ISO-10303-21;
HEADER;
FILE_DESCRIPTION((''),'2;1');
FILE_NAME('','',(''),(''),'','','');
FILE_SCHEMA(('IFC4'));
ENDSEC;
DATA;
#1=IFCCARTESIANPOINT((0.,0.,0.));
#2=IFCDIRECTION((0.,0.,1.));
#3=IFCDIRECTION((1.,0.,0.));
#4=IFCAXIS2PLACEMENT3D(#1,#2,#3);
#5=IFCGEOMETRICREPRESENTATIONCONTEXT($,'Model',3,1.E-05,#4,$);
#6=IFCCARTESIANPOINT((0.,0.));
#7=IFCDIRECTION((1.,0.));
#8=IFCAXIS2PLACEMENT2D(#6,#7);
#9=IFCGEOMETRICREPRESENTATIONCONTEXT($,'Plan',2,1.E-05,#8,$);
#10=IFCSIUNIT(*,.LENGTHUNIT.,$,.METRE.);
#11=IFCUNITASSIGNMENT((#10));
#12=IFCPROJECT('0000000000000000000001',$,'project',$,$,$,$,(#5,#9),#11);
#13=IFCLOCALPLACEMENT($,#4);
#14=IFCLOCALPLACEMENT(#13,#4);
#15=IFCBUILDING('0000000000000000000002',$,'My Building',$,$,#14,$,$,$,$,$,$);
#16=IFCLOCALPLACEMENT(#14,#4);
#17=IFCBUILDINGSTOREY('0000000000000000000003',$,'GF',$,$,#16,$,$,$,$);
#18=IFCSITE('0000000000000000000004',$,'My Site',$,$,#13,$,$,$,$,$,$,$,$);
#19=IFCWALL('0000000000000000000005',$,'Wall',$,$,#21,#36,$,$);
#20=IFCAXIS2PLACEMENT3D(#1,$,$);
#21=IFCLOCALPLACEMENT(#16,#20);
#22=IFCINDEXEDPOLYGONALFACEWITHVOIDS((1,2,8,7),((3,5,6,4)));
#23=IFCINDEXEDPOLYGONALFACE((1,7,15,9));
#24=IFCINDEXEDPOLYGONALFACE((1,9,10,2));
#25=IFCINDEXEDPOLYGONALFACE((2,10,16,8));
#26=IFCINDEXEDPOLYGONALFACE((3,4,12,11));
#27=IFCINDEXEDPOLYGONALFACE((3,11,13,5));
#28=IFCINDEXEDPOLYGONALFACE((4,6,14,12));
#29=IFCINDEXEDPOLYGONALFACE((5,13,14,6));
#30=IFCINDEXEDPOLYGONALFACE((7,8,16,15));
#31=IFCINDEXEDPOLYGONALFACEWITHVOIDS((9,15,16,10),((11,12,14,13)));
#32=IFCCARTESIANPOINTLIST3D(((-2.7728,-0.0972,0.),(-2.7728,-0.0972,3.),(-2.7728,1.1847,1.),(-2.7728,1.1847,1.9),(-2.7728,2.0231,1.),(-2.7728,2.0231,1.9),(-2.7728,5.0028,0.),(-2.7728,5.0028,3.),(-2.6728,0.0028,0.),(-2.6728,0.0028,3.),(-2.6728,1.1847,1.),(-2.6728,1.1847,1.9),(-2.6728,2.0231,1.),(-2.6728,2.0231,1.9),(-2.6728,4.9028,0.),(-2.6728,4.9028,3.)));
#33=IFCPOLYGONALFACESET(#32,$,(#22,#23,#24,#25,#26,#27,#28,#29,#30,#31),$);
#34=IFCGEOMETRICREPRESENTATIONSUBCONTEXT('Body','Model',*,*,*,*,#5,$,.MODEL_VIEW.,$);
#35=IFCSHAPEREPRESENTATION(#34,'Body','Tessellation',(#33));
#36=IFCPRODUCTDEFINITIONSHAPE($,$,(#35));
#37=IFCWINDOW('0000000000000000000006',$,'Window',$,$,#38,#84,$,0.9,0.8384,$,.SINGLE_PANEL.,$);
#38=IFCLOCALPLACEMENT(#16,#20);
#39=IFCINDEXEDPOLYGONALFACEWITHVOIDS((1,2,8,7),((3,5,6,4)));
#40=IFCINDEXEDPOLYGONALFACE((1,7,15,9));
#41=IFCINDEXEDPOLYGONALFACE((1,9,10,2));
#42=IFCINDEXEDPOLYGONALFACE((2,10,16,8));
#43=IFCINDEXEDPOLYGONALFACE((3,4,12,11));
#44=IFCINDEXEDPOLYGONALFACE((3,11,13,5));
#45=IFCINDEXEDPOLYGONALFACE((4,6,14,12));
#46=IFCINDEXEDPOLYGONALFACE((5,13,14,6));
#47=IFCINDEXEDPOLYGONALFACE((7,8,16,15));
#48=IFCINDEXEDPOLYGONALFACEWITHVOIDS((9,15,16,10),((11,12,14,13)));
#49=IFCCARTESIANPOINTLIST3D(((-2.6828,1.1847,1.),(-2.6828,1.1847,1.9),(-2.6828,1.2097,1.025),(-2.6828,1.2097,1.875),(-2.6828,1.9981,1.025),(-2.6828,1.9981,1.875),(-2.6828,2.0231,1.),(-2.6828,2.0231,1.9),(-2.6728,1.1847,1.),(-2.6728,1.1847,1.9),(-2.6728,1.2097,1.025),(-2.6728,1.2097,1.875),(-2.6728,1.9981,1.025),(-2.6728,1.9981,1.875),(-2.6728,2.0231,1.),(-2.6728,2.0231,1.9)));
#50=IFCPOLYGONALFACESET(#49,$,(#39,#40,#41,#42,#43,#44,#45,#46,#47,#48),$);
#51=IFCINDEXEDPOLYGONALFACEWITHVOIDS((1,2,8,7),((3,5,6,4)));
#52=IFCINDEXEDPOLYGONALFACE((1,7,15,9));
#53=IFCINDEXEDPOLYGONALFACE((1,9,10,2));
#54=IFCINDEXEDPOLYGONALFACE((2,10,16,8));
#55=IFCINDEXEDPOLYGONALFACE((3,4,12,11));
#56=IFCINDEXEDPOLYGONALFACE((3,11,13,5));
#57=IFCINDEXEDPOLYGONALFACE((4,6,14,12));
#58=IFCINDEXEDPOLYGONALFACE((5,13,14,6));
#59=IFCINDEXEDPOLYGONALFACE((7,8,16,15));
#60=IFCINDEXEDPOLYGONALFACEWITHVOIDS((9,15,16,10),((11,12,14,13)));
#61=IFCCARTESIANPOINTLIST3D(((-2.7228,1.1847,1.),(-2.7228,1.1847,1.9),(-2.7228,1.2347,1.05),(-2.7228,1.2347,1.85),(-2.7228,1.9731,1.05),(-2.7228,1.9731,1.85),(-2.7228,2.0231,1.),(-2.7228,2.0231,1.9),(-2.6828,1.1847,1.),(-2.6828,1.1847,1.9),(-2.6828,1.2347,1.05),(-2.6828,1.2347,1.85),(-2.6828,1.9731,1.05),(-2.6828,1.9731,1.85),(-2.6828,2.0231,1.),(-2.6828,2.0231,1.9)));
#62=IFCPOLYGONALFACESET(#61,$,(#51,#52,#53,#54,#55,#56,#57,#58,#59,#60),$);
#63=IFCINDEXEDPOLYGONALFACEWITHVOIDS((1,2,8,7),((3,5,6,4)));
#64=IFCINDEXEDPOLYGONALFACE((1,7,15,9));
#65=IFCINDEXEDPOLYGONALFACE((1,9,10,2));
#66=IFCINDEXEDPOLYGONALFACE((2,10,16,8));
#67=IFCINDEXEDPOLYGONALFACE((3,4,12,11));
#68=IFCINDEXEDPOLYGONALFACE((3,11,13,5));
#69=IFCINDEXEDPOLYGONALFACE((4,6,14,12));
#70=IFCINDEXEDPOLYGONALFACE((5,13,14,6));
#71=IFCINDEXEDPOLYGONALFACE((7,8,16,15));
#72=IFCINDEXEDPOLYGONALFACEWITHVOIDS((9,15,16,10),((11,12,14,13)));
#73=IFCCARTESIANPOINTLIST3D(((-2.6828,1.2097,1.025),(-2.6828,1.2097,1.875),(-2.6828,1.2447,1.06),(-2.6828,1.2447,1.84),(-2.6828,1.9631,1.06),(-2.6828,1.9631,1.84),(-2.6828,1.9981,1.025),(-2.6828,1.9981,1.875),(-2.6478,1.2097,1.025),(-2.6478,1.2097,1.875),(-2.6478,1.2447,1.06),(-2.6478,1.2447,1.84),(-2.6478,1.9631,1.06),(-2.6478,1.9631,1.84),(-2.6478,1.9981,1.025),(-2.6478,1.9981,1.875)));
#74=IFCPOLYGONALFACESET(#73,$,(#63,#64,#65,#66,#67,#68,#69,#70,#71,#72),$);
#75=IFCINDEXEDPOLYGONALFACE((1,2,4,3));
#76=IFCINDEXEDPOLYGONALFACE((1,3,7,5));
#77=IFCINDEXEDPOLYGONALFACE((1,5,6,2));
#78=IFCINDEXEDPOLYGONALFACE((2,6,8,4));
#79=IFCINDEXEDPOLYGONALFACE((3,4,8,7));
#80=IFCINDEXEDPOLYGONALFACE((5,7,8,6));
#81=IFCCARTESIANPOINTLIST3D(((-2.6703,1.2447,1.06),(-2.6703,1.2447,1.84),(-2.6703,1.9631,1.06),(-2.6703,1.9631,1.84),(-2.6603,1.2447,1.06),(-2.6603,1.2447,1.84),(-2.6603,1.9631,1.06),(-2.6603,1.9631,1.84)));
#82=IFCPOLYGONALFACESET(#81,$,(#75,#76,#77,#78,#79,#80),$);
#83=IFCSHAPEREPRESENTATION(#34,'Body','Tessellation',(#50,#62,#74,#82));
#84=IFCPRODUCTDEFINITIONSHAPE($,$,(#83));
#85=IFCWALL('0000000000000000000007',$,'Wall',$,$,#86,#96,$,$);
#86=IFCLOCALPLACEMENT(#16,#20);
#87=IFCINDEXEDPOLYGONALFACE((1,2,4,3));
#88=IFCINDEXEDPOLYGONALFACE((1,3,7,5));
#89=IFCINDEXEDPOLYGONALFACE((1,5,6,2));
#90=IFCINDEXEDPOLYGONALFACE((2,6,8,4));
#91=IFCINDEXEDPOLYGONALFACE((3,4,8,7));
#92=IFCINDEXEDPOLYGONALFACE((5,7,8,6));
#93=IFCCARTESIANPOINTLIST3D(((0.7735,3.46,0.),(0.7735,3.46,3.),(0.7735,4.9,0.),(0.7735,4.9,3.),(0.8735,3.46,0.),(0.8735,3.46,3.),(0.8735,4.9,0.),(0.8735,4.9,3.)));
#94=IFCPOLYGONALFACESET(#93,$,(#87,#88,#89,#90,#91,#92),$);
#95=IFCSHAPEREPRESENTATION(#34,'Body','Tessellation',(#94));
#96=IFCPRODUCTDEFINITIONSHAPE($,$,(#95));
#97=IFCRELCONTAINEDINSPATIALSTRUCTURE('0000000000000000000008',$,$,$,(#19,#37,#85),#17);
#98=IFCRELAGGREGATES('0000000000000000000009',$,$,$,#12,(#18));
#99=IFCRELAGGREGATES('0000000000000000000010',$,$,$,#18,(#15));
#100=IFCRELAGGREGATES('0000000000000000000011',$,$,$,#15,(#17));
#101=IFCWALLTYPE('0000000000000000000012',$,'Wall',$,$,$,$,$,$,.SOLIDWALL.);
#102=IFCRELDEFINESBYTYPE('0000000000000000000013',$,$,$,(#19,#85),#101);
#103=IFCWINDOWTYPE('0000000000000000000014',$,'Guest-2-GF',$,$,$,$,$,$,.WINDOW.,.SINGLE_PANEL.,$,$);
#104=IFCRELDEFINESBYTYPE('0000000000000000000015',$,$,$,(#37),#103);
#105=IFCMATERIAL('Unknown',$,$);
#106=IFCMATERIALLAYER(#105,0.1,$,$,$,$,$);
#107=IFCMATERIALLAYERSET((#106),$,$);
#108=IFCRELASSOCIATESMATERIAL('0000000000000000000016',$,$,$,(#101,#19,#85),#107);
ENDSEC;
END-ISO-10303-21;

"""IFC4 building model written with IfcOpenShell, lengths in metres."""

from ifc_helpers import new_model, entity, si_unit, frame, origin_with_axes, origin_2d_with_axis, place, context, subcontext, project, spatial, line, indexed_curve, outline, extrude, shape, source, transform, mapped, material, layer, layer_set, layer_usage, type_object, type_shapes, element, fill, save


model = new_model("IFC4")

# Units and contexts
model_context = context("Model", 3, precision=1e-05, world=origin_with_axes())
plan_context = context("Plan", 2, precision=1e-05, world=origin_2d_with_axis())
body_context_1 = subcontext(model_context, "Body", "Model", "MODEL_VIEW")
body_context_2 = subcontext(plan_context, "Body", "Plan", "PLAN_VIEW")
ifc_project = project(units=[si_unit("LENGTHUNIT", "METRE")], contexts=[model_context, plan_context])

# Site, building, storey
site_placement = place(None, origin_with_axes())
site = spatial("IfcSite", under=ifc_project, at=site_placement, Name="My Site")
building_placement = place(site_placement, origin_with_axes())
building = spatial("IfcBuilding", under=site, at=building_placement, Name="My Building")
storey_placement = place(building_placement, origin_with_axes())
storey = spatial("IfcBuildingStorey", under=building, at=storey_placement, Name="GF")

# Shared definitions
ifc_material_1 = material(Name="Unknown")

# Shared definitions
ifc_layer_1 = layer(ifc_material_1, 0.1)
ifc_layer_set_1 = layer_set([ifc_layer_1])
wall_type = type_object("IfcWallType", Name="Wall", PredefinedType="SOLIDWALL", material=ifc_layer_set_1)

# Wall, opening, window
ifc_layer_usage_1 = layer_usage(ifc_layer_set_1, "AXIS2", "POSITIVE", 0.0)
wall_1_placement = place(storey_placement, frame((-2.7728, 5.0028, 0.0), z_axis=(0.0, 0.0, 1.0), x_axis=(0.0, -1.0, 0.0)))
wall_1 = element("IfcWall", 1, at=wall_1_placement, inside=storey, type_object=wall_type, material=ifc_layer_usage_1, Name="Wall", context=body_context_1, shape_type="SweptSolid", body=[
    extrude(outline(indexed_curve([(0.0, 0.0), (0.1, 0.1), (5.0, 0.1), (5.1, 0.0)], segments=[line(1, 2, 3, 4, 1)])), origin_with_axes(), (0.0, 0.0, 1.0), 3.0),
])
shared_shape_1 = source(origin_with_axes(), body_context_1, "Body", "SweptSolid", [
    extrude(outline(indexed_curve([(0.0, 0.0), (0.8384, 0.0), (0.8384, 0.9), (0.0, 0.9)], segments=[line(1, 2, 3, 4, 1)])), frame((0.0, -0.6, 0.0), z_axis=(0.0, -1.0, 0.0), x_axis=(1.0, 0.0, 0.0)), (0.0, 0.0, -1.0), 1.2),
])
opening_1_placement = place(wall_1_placement, frame((2.9797, 0.0, 1.0), z_axis=(0.0, 0.0, 1.0), x_axis=(1.0, 0.0, 0.0)))
opening_1 = element("IfcOpeningElement", 2, at=opening_1_placement, cuts=wall_1, PredefinedType="OPENING", context=body_context_1, shape_type="MappedRepresentation", body=[
    mapped(shared_shape_1, transform((0.0, 0.0, 0.0), x_axis=(1.0, 0.0, 0.0), y_axis=(0.0, 1.0, 0.0), z_axis=(0.0, 0.0, 1.0), scale=1.0)),
])
window_type_1 = type_object("IfcWindowType", Name="Guest-2-GF", PartitioningType="SINGLE_PANEL", PredefinedType="WINDOW")
shared_shape_2 = source(origin_with_axes(), body_context_1, "Body", "SweptSolid", [
    extrude(outline(indexed_curve([(0.0, 0.0), (0.8384, 0.0), (0.8384, 0.9), (0.0, 0.9)], segments=[line(1, 2, 3, 4, 1)]), holes=[indexed_curve([(0.025, 0.025), (0.8134, 0.025), (0.8134, 0.875), (0.025, 0.875)], segments=[line(1, 2, 3, 4, 1)])]), frame((0.0, 0.09, 0.0), z_axis=(0.0, -1.0, 0.0), x_axis=(1.0, 0.0, 0.0)), (0.0, 0.0, -1.0), 0.01),
    extrude(outline(indexed_curve([(0.0, 0.0), (0.8384, 0.0), (0.8384, 0.9), (0.0, 0.9)], segments=[line(1, 2, 3, 4, 1)]), holes=[indexed_curve([(0.05, 0.05), (0.7884, 0.05), (0.7884, 0.85), (0.05, 0.85)], segments=[line(1, 2, 3, 4, 1)])]), frame((0.0, 0.05, 0.0), z_axis=(0.0, -1.0, 0.0), x_axis=(1.0, 0.0, 0.0)), (0.0, 0.0, -1.0), 0.04),
    extrude(outline(indexed_curve([(0.0, 0.0), (0.7884, 0.0), (0.7884, 0.85), (0.0, 0.85)], segments=[line(1, 2, 3, 4, 1)]), holes=[indexed_curve([(0.035, 0.035), (0.7534, 0.035), (0.7534, 0.815), (0.035, 0.815)], segments=[line(1, 2, 3, 4, 1)])]), frame((0.025, 0.09, 0.025), z_axis=(0.0, -1.0, 0.0), x_axis=(1.0, 0.0, 0.0)), (0.0, 0.0, -1.0), 0.035),
    extrude(outline(indexed_curve([(0.035, 0.035), (0.7534, 0.035), (0.7534, 0.815), (0.035, 0.815)], segments=[line(1, 2, 3, 4, 1)])), frame((0.025, 0.1025, 0.025), z_axis=(0.0, -1.0, 0.0), x_axis=(1.0, 0.0, 0.0)), (0.0, 0.0, -1.0), 0.01),
])
shared_shape_3 = source(origin_with_axes(), body_context_2, "Body", "Curve2D", [
    entity("IfcIndexedPolyCurve", entity("IfcCartesianPointList2D", [[0.05, 0.05], [0.7884, 0.05]])),
    entity("IfcIndexedPolyCurve", entity("IfcCartesianPointList2D", [[0.0, 0.1], [0.025, 0.1], [0.025, 0.09], [0.05, 0.09], [0.05, 0.05], [0.0, 0.05]]), [entity("IfcLineIndex", [1, 2, 3, 4, 5, 6, 1])]),
    entity("IfcIndexedPolyCurve", entity("IfcCartesianPointList2D", [[0.8384, 0.1], [0.8134, 0.1], [0.8134, 0.09], [0.7884, 0.09], [0.7884, 0.05], [0.8384, 0.05]]), [entity("IfcLineIndex", [1, 2, 3, 4, 5, 6, 1])]),
    entity("IfcIndexedPolyCurve", entity("IfcCartesianPointList2D", [[0.025, 0.09], [0.06, 0.09], [0.06, 0.125], [0.025, 0.125]]), [entity("IfcLineIndex", [1, 2, 3, 4, 1])]),
    entity("IfcIndexedPolyCurve", entity("IfcCartesianPointList2D", [[0.8134, 0.09], [0.7784, 0.09], [0.7784, 0.125], [0.8134, 0.125]]), [entity("IfcLineIndex", [1, 2, 3, 4, 1])]),
    entity("IfcIndexedPolyCurve", entity("IfcCartesianPointList2D", [[0.06, 0.09], [0.7784, 0.09]])),
    entity("IfcIndexedPolyCurve", entity("IfcCartesianPointList2D", [[0.06, 0.125], [0.7784, 0.125]])),
    entity("IfcIndexedPolyCurve", entity("IfcCartesianPointList2D", [[0.06, 0.1075], [0.7784, 0.1075]])),
])
type_shapes(window_type_1, [shared_shape_2, shared_shape_3])
window_1_placement = place(opening_1_placement, frame((0.0, 0.0, 0.0), z_axis=(0.0, 0.0, 1.0), x_axis=(1.0, 0.0, 0.0)))
window_1 = element("IfcWindow", 3, at=window_1_placement, inside=storey, type_object=window_type_1, Name="Window", OverallHeight=0.9, OverallWidth=0.8384, PartitioningType="SINGLE_PANEL", shapes=[
    shape(body_context_1, "Body", "MappedRepresentation", [mapped(shared_shape_2, transform((0.0, 0.0, 0.0), x_axis=(1.0, 0.0, 0.0), y_axis=(0.0, 1.0, 0.0), z_axis=(0.0, 0.0, 1.0), scale=1.0))]),
    shape(body_context_2, "Body", "MappedRepresentation", [mapped(shared_shape_3, transform((0.0, 0.0, 0.0), x_axis=(1.0, 0.0, 0.0), y_axis=(0.0, 1.0, 0.0), z_axis=(0.0, 0.0, 1.0), scale=1.0))]),
])
fill(opening_1, window_1)

# Wall
ifc_layer_usage_2 = layer_usage(ifc_layer_set_1, "AXIS2", "POSITIVE", 0.0)
wall_2_placement = place(storey_placement, frame((0.7735, 4.9, 0.0), z_axis=(0.0, 0.0, 1.0), x_axis=(0.0, -1.0, 0.0)))
element("IfcWall", 4, at=wall_2_placement, inside=storey, type_object=wall_type, material=ifc_layer_usage_2, Name="Wall", context=body_context_1, shape_type="SweptSolid", body=[
    extrude(outline(indexed_curve([(0.0, 0.0), (0.0, 0.1), (1.44, 0.1), (1.44, 0.0)], segments=[line(1, 2, 3, 4, 1)])), origin_with_axes(), (0.0, 0.0, 1.0), 3.0),
])

save(model, "model.ifc")
